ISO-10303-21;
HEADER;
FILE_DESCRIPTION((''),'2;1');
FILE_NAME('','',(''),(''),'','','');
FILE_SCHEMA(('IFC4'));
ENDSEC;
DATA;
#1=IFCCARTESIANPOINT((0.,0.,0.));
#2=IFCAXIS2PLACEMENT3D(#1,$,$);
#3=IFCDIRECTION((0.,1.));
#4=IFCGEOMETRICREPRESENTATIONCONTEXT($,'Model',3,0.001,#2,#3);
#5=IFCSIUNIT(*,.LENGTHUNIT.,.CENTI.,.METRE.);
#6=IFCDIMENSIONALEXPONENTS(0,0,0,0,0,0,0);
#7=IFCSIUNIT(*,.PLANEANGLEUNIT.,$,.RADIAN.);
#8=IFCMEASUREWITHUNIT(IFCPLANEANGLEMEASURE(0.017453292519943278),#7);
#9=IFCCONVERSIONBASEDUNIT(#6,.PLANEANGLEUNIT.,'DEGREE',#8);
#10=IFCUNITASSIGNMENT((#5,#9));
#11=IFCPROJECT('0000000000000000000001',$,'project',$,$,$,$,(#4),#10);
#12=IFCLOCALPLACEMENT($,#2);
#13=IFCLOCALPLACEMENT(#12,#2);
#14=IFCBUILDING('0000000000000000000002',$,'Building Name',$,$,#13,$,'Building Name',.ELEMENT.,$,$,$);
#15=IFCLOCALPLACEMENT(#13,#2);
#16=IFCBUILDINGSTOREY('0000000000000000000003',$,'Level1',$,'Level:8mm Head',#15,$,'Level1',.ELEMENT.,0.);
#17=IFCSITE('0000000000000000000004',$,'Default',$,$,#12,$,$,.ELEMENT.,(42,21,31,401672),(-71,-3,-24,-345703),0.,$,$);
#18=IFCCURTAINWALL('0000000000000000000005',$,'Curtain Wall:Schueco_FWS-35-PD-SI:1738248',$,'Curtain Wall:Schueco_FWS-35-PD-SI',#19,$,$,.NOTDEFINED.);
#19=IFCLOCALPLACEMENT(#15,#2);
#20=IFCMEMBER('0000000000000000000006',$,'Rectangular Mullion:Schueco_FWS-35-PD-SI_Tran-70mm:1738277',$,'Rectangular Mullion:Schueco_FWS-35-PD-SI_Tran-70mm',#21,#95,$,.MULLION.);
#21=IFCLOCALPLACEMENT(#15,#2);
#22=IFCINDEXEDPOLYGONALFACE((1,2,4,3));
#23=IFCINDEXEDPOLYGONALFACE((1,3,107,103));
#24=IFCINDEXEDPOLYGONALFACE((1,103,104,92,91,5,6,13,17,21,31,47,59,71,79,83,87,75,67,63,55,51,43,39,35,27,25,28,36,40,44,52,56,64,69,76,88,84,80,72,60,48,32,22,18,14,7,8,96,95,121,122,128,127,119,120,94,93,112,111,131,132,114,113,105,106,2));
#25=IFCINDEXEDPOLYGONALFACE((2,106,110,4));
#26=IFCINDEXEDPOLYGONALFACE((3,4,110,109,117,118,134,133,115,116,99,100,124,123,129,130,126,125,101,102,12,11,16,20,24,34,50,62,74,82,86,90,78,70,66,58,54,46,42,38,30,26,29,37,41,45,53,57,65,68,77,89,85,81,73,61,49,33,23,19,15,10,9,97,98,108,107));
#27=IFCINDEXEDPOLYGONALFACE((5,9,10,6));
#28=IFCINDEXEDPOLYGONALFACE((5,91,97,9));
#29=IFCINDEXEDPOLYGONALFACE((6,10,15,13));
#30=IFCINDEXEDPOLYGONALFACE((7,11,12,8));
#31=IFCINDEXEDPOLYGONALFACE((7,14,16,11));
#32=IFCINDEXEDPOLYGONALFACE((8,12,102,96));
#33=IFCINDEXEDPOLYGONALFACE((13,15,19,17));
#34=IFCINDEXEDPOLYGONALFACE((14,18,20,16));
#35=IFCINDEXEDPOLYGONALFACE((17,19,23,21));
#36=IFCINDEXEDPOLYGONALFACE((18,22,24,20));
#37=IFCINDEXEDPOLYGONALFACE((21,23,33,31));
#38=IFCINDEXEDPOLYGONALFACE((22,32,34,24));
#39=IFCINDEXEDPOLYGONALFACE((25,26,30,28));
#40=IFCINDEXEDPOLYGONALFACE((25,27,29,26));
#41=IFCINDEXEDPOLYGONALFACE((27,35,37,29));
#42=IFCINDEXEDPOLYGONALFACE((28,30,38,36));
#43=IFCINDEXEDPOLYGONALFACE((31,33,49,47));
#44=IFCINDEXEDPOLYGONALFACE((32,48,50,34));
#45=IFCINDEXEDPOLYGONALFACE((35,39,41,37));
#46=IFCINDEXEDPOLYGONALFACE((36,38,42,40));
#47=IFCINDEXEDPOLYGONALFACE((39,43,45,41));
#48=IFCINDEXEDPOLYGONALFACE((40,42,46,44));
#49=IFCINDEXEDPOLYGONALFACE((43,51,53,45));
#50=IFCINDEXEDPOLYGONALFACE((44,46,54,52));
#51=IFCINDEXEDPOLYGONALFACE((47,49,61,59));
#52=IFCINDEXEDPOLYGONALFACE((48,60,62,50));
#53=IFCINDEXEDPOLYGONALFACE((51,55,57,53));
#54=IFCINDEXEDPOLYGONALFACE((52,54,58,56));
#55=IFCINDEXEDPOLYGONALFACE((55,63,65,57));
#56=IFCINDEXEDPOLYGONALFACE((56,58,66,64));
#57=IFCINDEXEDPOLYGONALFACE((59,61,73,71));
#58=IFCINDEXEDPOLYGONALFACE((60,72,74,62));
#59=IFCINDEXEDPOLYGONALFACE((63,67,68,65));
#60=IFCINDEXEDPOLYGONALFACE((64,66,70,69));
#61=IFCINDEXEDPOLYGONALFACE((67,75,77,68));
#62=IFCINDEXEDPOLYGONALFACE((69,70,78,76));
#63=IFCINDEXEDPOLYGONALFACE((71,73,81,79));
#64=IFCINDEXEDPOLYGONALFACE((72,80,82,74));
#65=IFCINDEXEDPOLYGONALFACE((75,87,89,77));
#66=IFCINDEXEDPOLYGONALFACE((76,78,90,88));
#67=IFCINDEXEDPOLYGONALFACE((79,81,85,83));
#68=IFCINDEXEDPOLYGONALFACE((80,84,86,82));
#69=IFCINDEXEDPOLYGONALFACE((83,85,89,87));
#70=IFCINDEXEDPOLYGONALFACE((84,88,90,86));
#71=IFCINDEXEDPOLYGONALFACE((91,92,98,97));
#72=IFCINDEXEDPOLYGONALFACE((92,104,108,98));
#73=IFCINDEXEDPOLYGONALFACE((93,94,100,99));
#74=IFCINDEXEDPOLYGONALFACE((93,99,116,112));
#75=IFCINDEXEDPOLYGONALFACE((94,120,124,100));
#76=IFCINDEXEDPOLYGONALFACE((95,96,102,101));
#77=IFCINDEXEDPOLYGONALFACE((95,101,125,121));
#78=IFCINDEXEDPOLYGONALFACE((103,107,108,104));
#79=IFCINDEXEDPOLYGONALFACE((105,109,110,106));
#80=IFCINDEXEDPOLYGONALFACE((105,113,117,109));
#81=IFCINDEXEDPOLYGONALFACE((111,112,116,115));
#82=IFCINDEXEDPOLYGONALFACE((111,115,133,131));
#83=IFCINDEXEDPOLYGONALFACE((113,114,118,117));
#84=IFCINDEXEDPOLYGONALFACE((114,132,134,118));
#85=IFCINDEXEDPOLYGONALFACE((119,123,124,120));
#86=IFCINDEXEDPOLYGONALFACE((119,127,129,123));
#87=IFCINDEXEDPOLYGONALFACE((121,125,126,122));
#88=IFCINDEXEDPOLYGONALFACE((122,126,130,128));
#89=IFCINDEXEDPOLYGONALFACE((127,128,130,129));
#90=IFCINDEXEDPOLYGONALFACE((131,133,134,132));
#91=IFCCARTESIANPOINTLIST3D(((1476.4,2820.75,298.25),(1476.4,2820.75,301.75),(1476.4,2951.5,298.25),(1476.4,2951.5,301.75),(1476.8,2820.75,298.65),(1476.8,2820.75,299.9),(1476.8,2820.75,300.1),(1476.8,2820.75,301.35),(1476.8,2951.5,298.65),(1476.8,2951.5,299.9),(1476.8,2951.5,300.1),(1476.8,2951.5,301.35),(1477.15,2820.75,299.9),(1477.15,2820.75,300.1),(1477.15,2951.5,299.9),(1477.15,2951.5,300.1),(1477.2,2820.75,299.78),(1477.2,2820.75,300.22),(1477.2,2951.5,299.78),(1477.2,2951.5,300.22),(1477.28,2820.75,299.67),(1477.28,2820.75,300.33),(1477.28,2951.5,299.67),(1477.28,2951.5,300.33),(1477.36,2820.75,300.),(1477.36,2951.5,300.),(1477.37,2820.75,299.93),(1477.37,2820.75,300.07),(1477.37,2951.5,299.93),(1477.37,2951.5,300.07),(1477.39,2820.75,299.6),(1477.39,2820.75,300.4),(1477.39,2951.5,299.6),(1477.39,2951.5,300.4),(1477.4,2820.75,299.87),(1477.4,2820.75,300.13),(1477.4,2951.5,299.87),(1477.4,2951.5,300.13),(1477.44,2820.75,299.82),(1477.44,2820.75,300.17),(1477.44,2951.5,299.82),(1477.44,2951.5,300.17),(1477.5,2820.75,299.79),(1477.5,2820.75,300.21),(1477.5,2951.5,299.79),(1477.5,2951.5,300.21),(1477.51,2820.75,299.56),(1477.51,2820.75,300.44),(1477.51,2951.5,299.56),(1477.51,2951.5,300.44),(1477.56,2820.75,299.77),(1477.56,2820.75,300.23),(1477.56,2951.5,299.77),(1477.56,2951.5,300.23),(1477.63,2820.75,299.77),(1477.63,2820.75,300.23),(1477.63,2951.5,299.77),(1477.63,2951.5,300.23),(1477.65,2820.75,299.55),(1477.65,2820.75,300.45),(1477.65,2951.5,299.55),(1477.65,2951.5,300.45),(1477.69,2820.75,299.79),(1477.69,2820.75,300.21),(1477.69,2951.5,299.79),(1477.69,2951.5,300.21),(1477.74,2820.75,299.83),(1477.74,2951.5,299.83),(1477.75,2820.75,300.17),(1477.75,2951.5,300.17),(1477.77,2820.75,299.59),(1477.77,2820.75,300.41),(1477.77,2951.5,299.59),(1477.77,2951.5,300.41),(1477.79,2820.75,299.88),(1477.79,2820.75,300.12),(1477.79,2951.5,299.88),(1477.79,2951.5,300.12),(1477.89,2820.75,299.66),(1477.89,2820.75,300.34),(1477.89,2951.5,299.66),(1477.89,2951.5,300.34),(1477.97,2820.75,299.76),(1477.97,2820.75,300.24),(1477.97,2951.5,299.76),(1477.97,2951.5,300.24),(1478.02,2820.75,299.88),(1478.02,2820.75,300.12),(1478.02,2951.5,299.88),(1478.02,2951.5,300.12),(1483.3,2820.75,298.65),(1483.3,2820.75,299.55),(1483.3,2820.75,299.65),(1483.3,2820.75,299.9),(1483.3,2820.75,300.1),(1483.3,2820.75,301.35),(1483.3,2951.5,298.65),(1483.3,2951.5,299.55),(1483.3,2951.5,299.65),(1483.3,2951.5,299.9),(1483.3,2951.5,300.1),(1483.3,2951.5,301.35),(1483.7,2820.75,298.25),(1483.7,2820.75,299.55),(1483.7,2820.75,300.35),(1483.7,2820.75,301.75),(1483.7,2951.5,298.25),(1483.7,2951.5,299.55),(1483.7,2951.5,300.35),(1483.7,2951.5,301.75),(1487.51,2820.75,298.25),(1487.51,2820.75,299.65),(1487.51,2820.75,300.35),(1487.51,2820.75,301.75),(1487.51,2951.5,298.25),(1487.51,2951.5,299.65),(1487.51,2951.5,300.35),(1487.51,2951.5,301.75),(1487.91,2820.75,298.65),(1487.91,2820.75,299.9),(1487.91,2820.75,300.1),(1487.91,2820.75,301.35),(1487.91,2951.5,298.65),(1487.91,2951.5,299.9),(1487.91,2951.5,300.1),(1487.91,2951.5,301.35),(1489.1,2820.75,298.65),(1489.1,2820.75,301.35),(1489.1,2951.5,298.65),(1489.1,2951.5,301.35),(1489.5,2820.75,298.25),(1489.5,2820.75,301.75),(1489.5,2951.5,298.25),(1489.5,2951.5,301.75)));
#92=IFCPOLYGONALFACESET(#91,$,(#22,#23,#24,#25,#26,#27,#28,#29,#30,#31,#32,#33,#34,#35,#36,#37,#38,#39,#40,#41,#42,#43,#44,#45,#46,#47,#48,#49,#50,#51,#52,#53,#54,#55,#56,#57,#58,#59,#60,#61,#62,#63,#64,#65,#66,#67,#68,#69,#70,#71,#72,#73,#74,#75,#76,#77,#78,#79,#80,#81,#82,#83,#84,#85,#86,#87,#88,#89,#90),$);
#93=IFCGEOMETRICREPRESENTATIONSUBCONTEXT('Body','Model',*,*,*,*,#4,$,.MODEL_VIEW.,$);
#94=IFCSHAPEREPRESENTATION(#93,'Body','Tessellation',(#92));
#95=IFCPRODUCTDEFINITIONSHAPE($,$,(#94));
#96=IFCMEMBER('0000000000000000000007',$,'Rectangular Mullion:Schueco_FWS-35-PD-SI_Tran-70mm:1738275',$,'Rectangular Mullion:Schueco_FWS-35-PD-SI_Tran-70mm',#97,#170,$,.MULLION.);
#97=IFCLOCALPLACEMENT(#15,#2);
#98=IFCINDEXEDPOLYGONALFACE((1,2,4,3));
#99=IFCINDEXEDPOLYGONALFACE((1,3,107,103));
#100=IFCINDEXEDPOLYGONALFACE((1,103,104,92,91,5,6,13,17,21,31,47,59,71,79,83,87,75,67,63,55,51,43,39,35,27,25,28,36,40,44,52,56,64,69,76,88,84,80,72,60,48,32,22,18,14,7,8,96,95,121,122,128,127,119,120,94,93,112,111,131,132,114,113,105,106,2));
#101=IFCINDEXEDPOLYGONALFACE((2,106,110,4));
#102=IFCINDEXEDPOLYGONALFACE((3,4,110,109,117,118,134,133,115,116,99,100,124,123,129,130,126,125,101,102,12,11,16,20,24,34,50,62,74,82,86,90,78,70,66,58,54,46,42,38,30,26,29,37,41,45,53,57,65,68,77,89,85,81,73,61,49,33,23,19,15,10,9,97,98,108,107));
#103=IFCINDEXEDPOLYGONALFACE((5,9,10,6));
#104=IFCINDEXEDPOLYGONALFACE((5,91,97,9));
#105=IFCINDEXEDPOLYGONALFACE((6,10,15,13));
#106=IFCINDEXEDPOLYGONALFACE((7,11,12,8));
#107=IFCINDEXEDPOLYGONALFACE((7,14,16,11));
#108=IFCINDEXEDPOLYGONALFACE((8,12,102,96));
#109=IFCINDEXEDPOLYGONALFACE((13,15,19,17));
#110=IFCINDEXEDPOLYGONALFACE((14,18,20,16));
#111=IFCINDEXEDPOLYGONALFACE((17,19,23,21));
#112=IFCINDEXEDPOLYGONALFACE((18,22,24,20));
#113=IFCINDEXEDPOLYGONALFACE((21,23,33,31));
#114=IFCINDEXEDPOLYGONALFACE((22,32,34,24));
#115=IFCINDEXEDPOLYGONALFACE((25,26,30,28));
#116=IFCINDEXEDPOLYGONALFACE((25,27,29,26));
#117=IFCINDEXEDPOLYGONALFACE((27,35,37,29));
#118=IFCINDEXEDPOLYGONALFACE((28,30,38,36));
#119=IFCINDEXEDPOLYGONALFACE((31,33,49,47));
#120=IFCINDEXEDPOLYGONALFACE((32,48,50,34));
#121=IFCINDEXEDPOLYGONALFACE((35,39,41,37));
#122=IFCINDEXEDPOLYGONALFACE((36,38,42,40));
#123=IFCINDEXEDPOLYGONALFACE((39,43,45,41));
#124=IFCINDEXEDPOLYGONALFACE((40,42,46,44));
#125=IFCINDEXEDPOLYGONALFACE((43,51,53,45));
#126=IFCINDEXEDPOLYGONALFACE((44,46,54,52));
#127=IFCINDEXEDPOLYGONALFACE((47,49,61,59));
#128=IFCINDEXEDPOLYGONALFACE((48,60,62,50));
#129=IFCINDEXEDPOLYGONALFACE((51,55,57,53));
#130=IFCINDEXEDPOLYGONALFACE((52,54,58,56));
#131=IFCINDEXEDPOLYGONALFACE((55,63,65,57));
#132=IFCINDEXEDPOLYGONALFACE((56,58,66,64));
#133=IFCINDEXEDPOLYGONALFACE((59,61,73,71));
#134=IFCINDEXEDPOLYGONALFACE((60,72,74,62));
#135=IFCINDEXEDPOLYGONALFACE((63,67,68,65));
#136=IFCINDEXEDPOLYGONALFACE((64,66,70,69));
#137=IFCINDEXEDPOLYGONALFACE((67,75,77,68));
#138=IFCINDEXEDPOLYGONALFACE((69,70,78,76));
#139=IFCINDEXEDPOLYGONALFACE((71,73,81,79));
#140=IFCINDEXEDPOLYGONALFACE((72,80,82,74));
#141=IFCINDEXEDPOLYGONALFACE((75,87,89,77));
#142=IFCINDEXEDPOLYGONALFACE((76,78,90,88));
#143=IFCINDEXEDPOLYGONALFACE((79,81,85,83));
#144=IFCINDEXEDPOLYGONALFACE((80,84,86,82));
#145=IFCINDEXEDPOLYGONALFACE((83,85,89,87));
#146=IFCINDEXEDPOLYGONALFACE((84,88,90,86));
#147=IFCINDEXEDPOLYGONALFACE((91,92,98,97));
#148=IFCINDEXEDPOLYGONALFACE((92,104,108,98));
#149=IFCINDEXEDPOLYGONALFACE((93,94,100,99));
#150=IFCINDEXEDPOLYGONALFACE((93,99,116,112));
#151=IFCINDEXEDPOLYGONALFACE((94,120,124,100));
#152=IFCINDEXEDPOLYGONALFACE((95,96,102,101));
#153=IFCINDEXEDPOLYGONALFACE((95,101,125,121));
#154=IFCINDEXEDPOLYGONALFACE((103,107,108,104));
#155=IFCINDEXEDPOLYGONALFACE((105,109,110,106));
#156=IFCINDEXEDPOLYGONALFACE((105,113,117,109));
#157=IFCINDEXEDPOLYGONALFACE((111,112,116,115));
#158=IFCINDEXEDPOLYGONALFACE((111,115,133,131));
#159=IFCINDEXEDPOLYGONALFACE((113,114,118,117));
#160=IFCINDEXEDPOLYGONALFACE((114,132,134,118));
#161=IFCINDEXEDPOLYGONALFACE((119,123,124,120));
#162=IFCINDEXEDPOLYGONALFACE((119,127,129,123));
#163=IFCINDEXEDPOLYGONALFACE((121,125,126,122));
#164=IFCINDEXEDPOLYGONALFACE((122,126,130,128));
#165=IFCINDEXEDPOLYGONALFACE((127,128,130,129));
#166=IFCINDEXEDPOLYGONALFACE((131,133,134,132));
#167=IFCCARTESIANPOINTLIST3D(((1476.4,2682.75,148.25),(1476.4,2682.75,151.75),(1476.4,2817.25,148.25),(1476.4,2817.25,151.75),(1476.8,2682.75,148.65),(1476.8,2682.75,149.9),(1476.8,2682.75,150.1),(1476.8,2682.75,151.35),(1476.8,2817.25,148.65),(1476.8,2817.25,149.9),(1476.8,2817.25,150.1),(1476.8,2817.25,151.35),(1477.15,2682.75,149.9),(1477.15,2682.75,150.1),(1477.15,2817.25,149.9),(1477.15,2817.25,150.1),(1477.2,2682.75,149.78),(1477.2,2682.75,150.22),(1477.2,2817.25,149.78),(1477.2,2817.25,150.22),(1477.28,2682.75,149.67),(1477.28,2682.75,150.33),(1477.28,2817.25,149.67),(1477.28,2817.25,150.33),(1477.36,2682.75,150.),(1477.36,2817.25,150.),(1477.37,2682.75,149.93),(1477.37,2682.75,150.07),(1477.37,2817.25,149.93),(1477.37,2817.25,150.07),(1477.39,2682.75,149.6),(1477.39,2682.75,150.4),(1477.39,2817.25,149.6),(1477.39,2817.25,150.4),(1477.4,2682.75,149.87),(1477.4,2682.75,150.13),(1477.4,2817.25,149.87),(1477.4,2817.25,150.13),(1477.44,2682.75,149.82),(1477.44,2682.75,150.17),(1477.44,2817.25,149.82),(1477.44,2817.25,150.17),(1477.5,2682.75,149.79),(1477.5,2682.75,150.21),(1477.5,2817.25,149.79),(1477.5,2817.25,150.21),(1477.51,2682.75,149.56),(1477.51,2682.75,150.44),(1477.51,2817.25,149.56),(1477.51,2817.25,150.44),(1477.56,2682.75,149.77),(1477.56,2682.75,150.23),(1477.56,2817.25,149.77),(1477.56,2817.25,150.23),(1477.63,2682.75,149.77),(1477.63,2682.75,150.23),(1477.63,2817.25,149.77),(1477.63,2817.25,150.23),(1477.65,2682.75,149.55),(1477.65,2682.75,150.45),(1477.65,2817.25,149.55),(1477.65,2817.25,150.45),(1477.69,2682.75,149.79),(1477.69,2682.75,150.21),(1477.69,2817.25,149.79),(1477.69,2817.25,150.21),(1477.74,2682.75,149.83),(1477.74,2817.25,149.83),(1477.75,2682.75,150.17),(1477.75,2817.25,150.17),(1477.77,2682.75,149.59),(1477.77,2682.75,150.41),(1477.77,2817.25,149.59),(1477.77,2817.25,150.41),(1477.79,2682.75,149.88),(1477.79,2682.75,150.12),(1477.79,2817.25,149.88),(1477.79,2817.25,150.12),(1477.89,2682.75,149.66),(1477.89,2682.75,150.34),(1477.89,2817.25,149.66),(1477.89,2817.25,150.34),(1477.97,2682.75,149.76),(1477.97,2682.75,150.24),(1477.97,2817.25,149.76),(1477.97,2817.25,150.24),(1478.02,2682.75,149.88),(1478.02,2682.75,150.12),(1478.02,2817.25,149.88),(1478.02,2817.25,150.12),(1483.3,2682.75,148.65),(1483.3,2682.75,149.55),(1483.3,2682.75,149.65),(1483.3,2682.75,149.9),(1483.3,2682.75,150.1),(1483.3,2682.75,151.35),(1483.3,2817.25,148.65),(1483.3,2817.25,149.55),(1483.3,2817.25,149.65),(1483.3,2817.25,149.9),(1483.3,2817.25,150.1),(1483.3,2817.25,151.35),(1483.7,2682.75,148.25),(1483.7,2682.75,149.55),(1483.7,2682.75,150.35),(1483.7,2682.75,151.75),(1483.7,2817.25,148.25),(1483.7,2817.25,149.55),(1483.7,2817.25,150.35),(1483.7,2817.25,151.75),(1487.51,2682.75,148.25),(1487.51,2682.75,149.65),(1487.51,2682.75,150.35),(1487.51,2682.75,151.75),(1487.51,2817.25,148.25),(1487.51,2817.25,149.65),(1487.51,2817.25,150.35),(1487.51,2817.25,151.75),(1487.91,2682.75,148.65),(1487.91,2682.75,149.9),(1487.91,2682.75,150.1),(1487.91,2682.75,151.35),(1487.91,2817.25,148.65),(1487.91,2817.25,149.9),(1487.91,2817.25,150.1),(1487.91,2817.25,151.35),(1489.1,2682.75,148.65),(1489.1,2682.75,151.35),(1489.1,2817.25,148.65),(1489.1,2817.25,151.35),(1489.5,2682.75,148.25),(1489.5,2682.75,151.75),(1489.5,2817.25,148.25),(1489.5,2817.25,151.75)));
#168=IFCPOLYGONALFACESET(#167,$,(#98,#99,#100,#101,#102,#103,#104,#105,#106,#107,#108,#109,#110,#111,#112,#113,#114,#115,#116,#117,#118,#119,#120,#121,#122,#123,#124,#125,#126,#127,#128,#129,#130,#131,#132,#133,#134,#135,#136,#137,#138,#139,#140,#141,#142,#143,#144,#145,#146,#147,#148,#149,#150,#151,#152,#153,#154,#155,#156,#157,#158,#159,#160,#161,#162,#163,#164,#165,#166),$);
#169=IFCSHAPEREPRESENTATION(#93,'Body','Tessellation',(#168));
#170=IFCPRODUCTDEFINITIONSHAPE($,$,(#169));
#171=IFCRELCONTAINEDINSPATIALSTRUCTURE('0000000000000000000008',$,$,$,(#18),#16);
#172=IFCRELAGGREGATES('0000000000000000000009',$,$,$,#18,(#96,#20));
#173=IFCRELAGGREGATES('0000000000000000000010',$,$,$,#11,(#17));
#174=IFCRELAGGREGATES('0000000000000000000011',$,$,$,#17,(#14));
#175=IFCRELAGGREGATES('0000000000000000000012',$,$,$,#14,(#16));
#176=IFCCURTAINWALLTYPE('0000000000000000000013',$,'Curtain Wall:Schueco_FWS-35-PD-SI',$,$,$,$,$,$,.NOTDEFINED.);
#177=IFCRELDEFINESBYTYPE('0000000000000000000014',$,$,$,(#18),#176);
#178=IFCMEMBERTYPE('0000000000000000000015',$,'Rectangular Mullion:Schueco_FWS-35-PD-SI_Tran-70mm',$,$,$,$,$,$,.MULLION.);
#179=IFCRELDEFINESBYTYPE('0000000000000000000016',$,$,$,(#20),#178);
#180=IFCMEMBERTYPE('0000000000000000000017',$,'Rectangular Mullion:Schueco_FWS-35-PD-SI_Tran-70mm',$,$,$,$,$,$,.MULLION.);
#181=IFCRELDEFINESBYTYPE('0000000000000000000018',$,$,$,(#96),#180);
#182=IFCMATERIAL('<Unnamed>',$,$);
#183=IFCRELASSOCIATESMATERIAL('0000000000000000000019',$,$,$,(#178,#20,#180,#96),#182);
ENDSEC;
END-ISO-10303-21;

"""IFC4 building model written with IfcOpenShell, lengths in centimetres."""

from ifc_helpers import new_model, entity, si_unit, converted_unit, direction, frame, origin, place, context, subcontext, project, spatial, line, arc, indexed_curve, outline, extrude, source, transform, mapped, material, type_object, type_shapes, element, aggregate, save


model = new_model("IFC4")

# Units and contexts
model_context = context("Model", 3, precision=0.001, world=origin(), true_north=direction((0.0, 1.0)))
body_context = subcontext(model_context, "Body", "Model", "MODEL_VIEW")
ifc_project = project(units=[si_unit("LENGTHUNIT", "METRE", prefix="CENTI"), converted_unit("PLANEANGLEUNIT", "DEGREE", entity("IfcPlaneAngleMeasure", 0.017453292519943278), si_unit("PLANEANGLEUNIT", "RADIAN"), dimensions=[0, 0, 0, 0, 0, 0, 0])], contexts=[model_context])

# Site, building, storey
site_placement = place(None, origin())
site = spatial("IfcSite", under=ifc_project, at=site_placement, Name="Default", CompositionType="ELEMENT", RefLatitude=(42, 21, 31, 401672), RefLongitude=(-71, -3, -24, -345703), RefElevation=0.0)
building_placement = place(site_placement, origin())
building = spatial("IfcBuilding", under=site, at=building_placement, Name="Building Name", LongName="Building Name", CompositionType="ELEMENT")
storey_placement = place(building_placement, origin())
storey = spatial("IfcBuildingStorey", under=building, at=storey_placement, Name="Level1", ObjectType="Level:8mm Head", LongName="Level1", CompositionType="ELEMENT", Elevation=0.0)

# Curtain wall, members
curtain_wall_type = type_object("IfcCurtainWallType", Name="Curtain Wall:Schueco_FWS-35-PD-SI", PredefinedType="NOTDEFINED")
curtain_wall_placement = place(storey_placement, origin())
curtain_wall = element("IfcCurtainWall", 1, at=curtain_wall_placement, inside=storey, type_object=curtain_wall_type, Name="Curtain Wall:Schueco_FWS-35-PD-SI:1738248", ObjectType="Curtain Wall:Schueco_FWS-35-PD-SI", PredefinedType="NOTDEFINED")
ifc_material_1 = material(Name="<Unnamed>")
member_type_1 = type_object("IfcMemberType", Name="Rectangular Mullion:Schueco_FWS-35-PD-SI_Tran-70mm", PredefinedType="MULLION", material=ifc_material_1)
shared_shape_1 = source(origin(), body_context, "Body", "SweptSolid", [
    extrude(outline(indexed_curve([(-1.78, -6.52), (1.72, -6.52), (1.72, 0.78), (0.42, 0.78), (0.42, 0.38), (1.32, 0.38), (1.32, -6.12), (0.07, -6.12), (0.07, -5.77), (0.42, -5.34), (0.09, -4.9), (0.09, -5.14), (-0.03, -5.56), (-0.15, -5.14), (-0.15, -4.9), (-0.48, -5.34), (-0.13, -5.77), (-0.13, -6.12), (-1.38, -6.12), (-1.38, 0.38), (-0.13, 0.38), (-0.13, 4.99), (-1.38, 4.99), (-1.38, 6.18), (1.32, 6.18), (1.32, 4.99), (0.07, 4.99), (0.07, 0.38), (0.32, 0.38), (0.32, 4.59), (1.72, 4.59), (1.72, 6.58), (-1.78, 6.58), (-1.78, 4.59), (-0.38, 4.59), (-0.38, 0.78), (-1.78, 0.78)], segments=[line(1, 2, 3, 4, 5, 6, 7, 8, 9), arc(9, 10, 11), line(11, 12), arc(12, 13, 14), line(14, 15), arc(15, 16, 17), line(17, 18, 19, 20, 21, 22, 23, 24, 25, 26, 27, 28, 29, 30, 31, 32, 33, 34, 35, 36, 37, 1)], self_intersect=False)), frame((-0.03, 4.58, -130.75), z_axis=(0.0, 0.0, 1.0), x_axis=(-1.0, 0.0, 0.0)), (0.0, 0.0, 1.0), 130.75),
])
type_shapes(member_type_1, [shared_shape_1])
member_1_placement = place(curtain_wall_placement, frame((1487.5, 2820.75, 300.0), z_axis=(0.0, -1.0, 0.0), x_axis=(0.0, 0.0, 1.0)))
member_1 = element("IfcMember", 2, at=member_1_placement, type_object=member_type_1, material=ifc_material_1, Name="Rectangular Mullion:Schueco_FWS-35-PD-SI_Tran-70mm:1738277", ObjectType="Rectangular Mullion:Schueco_FWS-35-PD-SI_Tran-70mm", PredefinedType="MULLION", context=body_context, shape_type="MappedRepresentation", body=[
    mapped(shared_shape_1, transform((0.0, 0.0, 0.0), scale=1.0)),
])
member_type_2 = type_object("IfcMemberType", Name="Rectangular Mullion:Schueco_FWS-35-PD-SI_Tran-70mm", PredefinedType="MULLION", material=ifc_material_1)
shared_shape_2 = source(origin(), body_context, "Body", "SweptSolid", [
    extrude(outline(indexed_curve([(-1.78, -6.52), (1.72, -6.52), (1.72, 0.78), (0.42, 0.78), (0.42, 0.38), (1.32, 0.38), (1.32, -6.12), (0.07, -6.12), (0.07, -5.77), (0.42, -5.34), (0.09, -4.9), (0.09, -5.14), (-0.03, -5.56), (-0.15, -5.14), (-0.15, -4.9), (-0.48, -5.34), (-0.13, -5.77), (-0.13, -6.12), (-1.38, -6.12), (-1.38, 0.38), (-0.13, 0.38), (-0.13, 4.99), (-1.38, 4.99), (-1.38, 6.18), (1.32, 6.18), (1.32, 4.99), (0.07, 4.99), (0.07, 0.38), (0.32, 0.38), (0.32, 4.59), (1.72, 4.59), (1.72, 6.58), (-1.78, 6.58), (-1.78, 4.59), (-0.38, 4.59), (-0.38, 0.78), (-1.78, 0.78)], segments=[line(1, 2, 3, 4, 5, 6, 7, 8, 9), arc(9, 10, 11), line(11, 12), arc(12, 13, 14), line(14, 15), arc(15, 16, 17), line(17, 18, 19, 20, 21, 22, 23, 24, 25, 26, 27, 28, 29, 30, 31, 32, 33, 34, 35, 36, 37, 1)], self_intersect=False)), frame((-0.03, 4.58, -134.5), z_axis=(0.0, 0.0, 1.0), x_axis=(-1.0, 0.0, 0.0)), (0.0, 0.0, 1.0), 134.5),
])
type_shapes(member_type_2, [shared_shape_2])
member_2_placement = place(curtain_wall_placement, frame((1487.5, 2682.75, 150.0), z_axis=(0.0, -1.0, 0.0), x_axis=(0.0, 0.0, 1.0)))
member_2 = element("IfcMember", 3, at=member_2_placement, type_object=member_type_2, material=ifc_material_1, Name="Rectangular Mullion:Schueco_FWS-35-PD-SI_Tran-70mm:1738275", ObjectType="Rectangular Mullion:Schueco_FWS-35-PD-SI_Tran-70mm", PredefinedType="MULLION", context=body_context, shape_type="MappedRepresentation", body=[
    mapped(shared_shape_2, transform((0.0, 0.0, 0.0), scale=1.0)),
])
aggregate(curtain_wall, [member_2, member_1])

save(model, "model.ifc")
